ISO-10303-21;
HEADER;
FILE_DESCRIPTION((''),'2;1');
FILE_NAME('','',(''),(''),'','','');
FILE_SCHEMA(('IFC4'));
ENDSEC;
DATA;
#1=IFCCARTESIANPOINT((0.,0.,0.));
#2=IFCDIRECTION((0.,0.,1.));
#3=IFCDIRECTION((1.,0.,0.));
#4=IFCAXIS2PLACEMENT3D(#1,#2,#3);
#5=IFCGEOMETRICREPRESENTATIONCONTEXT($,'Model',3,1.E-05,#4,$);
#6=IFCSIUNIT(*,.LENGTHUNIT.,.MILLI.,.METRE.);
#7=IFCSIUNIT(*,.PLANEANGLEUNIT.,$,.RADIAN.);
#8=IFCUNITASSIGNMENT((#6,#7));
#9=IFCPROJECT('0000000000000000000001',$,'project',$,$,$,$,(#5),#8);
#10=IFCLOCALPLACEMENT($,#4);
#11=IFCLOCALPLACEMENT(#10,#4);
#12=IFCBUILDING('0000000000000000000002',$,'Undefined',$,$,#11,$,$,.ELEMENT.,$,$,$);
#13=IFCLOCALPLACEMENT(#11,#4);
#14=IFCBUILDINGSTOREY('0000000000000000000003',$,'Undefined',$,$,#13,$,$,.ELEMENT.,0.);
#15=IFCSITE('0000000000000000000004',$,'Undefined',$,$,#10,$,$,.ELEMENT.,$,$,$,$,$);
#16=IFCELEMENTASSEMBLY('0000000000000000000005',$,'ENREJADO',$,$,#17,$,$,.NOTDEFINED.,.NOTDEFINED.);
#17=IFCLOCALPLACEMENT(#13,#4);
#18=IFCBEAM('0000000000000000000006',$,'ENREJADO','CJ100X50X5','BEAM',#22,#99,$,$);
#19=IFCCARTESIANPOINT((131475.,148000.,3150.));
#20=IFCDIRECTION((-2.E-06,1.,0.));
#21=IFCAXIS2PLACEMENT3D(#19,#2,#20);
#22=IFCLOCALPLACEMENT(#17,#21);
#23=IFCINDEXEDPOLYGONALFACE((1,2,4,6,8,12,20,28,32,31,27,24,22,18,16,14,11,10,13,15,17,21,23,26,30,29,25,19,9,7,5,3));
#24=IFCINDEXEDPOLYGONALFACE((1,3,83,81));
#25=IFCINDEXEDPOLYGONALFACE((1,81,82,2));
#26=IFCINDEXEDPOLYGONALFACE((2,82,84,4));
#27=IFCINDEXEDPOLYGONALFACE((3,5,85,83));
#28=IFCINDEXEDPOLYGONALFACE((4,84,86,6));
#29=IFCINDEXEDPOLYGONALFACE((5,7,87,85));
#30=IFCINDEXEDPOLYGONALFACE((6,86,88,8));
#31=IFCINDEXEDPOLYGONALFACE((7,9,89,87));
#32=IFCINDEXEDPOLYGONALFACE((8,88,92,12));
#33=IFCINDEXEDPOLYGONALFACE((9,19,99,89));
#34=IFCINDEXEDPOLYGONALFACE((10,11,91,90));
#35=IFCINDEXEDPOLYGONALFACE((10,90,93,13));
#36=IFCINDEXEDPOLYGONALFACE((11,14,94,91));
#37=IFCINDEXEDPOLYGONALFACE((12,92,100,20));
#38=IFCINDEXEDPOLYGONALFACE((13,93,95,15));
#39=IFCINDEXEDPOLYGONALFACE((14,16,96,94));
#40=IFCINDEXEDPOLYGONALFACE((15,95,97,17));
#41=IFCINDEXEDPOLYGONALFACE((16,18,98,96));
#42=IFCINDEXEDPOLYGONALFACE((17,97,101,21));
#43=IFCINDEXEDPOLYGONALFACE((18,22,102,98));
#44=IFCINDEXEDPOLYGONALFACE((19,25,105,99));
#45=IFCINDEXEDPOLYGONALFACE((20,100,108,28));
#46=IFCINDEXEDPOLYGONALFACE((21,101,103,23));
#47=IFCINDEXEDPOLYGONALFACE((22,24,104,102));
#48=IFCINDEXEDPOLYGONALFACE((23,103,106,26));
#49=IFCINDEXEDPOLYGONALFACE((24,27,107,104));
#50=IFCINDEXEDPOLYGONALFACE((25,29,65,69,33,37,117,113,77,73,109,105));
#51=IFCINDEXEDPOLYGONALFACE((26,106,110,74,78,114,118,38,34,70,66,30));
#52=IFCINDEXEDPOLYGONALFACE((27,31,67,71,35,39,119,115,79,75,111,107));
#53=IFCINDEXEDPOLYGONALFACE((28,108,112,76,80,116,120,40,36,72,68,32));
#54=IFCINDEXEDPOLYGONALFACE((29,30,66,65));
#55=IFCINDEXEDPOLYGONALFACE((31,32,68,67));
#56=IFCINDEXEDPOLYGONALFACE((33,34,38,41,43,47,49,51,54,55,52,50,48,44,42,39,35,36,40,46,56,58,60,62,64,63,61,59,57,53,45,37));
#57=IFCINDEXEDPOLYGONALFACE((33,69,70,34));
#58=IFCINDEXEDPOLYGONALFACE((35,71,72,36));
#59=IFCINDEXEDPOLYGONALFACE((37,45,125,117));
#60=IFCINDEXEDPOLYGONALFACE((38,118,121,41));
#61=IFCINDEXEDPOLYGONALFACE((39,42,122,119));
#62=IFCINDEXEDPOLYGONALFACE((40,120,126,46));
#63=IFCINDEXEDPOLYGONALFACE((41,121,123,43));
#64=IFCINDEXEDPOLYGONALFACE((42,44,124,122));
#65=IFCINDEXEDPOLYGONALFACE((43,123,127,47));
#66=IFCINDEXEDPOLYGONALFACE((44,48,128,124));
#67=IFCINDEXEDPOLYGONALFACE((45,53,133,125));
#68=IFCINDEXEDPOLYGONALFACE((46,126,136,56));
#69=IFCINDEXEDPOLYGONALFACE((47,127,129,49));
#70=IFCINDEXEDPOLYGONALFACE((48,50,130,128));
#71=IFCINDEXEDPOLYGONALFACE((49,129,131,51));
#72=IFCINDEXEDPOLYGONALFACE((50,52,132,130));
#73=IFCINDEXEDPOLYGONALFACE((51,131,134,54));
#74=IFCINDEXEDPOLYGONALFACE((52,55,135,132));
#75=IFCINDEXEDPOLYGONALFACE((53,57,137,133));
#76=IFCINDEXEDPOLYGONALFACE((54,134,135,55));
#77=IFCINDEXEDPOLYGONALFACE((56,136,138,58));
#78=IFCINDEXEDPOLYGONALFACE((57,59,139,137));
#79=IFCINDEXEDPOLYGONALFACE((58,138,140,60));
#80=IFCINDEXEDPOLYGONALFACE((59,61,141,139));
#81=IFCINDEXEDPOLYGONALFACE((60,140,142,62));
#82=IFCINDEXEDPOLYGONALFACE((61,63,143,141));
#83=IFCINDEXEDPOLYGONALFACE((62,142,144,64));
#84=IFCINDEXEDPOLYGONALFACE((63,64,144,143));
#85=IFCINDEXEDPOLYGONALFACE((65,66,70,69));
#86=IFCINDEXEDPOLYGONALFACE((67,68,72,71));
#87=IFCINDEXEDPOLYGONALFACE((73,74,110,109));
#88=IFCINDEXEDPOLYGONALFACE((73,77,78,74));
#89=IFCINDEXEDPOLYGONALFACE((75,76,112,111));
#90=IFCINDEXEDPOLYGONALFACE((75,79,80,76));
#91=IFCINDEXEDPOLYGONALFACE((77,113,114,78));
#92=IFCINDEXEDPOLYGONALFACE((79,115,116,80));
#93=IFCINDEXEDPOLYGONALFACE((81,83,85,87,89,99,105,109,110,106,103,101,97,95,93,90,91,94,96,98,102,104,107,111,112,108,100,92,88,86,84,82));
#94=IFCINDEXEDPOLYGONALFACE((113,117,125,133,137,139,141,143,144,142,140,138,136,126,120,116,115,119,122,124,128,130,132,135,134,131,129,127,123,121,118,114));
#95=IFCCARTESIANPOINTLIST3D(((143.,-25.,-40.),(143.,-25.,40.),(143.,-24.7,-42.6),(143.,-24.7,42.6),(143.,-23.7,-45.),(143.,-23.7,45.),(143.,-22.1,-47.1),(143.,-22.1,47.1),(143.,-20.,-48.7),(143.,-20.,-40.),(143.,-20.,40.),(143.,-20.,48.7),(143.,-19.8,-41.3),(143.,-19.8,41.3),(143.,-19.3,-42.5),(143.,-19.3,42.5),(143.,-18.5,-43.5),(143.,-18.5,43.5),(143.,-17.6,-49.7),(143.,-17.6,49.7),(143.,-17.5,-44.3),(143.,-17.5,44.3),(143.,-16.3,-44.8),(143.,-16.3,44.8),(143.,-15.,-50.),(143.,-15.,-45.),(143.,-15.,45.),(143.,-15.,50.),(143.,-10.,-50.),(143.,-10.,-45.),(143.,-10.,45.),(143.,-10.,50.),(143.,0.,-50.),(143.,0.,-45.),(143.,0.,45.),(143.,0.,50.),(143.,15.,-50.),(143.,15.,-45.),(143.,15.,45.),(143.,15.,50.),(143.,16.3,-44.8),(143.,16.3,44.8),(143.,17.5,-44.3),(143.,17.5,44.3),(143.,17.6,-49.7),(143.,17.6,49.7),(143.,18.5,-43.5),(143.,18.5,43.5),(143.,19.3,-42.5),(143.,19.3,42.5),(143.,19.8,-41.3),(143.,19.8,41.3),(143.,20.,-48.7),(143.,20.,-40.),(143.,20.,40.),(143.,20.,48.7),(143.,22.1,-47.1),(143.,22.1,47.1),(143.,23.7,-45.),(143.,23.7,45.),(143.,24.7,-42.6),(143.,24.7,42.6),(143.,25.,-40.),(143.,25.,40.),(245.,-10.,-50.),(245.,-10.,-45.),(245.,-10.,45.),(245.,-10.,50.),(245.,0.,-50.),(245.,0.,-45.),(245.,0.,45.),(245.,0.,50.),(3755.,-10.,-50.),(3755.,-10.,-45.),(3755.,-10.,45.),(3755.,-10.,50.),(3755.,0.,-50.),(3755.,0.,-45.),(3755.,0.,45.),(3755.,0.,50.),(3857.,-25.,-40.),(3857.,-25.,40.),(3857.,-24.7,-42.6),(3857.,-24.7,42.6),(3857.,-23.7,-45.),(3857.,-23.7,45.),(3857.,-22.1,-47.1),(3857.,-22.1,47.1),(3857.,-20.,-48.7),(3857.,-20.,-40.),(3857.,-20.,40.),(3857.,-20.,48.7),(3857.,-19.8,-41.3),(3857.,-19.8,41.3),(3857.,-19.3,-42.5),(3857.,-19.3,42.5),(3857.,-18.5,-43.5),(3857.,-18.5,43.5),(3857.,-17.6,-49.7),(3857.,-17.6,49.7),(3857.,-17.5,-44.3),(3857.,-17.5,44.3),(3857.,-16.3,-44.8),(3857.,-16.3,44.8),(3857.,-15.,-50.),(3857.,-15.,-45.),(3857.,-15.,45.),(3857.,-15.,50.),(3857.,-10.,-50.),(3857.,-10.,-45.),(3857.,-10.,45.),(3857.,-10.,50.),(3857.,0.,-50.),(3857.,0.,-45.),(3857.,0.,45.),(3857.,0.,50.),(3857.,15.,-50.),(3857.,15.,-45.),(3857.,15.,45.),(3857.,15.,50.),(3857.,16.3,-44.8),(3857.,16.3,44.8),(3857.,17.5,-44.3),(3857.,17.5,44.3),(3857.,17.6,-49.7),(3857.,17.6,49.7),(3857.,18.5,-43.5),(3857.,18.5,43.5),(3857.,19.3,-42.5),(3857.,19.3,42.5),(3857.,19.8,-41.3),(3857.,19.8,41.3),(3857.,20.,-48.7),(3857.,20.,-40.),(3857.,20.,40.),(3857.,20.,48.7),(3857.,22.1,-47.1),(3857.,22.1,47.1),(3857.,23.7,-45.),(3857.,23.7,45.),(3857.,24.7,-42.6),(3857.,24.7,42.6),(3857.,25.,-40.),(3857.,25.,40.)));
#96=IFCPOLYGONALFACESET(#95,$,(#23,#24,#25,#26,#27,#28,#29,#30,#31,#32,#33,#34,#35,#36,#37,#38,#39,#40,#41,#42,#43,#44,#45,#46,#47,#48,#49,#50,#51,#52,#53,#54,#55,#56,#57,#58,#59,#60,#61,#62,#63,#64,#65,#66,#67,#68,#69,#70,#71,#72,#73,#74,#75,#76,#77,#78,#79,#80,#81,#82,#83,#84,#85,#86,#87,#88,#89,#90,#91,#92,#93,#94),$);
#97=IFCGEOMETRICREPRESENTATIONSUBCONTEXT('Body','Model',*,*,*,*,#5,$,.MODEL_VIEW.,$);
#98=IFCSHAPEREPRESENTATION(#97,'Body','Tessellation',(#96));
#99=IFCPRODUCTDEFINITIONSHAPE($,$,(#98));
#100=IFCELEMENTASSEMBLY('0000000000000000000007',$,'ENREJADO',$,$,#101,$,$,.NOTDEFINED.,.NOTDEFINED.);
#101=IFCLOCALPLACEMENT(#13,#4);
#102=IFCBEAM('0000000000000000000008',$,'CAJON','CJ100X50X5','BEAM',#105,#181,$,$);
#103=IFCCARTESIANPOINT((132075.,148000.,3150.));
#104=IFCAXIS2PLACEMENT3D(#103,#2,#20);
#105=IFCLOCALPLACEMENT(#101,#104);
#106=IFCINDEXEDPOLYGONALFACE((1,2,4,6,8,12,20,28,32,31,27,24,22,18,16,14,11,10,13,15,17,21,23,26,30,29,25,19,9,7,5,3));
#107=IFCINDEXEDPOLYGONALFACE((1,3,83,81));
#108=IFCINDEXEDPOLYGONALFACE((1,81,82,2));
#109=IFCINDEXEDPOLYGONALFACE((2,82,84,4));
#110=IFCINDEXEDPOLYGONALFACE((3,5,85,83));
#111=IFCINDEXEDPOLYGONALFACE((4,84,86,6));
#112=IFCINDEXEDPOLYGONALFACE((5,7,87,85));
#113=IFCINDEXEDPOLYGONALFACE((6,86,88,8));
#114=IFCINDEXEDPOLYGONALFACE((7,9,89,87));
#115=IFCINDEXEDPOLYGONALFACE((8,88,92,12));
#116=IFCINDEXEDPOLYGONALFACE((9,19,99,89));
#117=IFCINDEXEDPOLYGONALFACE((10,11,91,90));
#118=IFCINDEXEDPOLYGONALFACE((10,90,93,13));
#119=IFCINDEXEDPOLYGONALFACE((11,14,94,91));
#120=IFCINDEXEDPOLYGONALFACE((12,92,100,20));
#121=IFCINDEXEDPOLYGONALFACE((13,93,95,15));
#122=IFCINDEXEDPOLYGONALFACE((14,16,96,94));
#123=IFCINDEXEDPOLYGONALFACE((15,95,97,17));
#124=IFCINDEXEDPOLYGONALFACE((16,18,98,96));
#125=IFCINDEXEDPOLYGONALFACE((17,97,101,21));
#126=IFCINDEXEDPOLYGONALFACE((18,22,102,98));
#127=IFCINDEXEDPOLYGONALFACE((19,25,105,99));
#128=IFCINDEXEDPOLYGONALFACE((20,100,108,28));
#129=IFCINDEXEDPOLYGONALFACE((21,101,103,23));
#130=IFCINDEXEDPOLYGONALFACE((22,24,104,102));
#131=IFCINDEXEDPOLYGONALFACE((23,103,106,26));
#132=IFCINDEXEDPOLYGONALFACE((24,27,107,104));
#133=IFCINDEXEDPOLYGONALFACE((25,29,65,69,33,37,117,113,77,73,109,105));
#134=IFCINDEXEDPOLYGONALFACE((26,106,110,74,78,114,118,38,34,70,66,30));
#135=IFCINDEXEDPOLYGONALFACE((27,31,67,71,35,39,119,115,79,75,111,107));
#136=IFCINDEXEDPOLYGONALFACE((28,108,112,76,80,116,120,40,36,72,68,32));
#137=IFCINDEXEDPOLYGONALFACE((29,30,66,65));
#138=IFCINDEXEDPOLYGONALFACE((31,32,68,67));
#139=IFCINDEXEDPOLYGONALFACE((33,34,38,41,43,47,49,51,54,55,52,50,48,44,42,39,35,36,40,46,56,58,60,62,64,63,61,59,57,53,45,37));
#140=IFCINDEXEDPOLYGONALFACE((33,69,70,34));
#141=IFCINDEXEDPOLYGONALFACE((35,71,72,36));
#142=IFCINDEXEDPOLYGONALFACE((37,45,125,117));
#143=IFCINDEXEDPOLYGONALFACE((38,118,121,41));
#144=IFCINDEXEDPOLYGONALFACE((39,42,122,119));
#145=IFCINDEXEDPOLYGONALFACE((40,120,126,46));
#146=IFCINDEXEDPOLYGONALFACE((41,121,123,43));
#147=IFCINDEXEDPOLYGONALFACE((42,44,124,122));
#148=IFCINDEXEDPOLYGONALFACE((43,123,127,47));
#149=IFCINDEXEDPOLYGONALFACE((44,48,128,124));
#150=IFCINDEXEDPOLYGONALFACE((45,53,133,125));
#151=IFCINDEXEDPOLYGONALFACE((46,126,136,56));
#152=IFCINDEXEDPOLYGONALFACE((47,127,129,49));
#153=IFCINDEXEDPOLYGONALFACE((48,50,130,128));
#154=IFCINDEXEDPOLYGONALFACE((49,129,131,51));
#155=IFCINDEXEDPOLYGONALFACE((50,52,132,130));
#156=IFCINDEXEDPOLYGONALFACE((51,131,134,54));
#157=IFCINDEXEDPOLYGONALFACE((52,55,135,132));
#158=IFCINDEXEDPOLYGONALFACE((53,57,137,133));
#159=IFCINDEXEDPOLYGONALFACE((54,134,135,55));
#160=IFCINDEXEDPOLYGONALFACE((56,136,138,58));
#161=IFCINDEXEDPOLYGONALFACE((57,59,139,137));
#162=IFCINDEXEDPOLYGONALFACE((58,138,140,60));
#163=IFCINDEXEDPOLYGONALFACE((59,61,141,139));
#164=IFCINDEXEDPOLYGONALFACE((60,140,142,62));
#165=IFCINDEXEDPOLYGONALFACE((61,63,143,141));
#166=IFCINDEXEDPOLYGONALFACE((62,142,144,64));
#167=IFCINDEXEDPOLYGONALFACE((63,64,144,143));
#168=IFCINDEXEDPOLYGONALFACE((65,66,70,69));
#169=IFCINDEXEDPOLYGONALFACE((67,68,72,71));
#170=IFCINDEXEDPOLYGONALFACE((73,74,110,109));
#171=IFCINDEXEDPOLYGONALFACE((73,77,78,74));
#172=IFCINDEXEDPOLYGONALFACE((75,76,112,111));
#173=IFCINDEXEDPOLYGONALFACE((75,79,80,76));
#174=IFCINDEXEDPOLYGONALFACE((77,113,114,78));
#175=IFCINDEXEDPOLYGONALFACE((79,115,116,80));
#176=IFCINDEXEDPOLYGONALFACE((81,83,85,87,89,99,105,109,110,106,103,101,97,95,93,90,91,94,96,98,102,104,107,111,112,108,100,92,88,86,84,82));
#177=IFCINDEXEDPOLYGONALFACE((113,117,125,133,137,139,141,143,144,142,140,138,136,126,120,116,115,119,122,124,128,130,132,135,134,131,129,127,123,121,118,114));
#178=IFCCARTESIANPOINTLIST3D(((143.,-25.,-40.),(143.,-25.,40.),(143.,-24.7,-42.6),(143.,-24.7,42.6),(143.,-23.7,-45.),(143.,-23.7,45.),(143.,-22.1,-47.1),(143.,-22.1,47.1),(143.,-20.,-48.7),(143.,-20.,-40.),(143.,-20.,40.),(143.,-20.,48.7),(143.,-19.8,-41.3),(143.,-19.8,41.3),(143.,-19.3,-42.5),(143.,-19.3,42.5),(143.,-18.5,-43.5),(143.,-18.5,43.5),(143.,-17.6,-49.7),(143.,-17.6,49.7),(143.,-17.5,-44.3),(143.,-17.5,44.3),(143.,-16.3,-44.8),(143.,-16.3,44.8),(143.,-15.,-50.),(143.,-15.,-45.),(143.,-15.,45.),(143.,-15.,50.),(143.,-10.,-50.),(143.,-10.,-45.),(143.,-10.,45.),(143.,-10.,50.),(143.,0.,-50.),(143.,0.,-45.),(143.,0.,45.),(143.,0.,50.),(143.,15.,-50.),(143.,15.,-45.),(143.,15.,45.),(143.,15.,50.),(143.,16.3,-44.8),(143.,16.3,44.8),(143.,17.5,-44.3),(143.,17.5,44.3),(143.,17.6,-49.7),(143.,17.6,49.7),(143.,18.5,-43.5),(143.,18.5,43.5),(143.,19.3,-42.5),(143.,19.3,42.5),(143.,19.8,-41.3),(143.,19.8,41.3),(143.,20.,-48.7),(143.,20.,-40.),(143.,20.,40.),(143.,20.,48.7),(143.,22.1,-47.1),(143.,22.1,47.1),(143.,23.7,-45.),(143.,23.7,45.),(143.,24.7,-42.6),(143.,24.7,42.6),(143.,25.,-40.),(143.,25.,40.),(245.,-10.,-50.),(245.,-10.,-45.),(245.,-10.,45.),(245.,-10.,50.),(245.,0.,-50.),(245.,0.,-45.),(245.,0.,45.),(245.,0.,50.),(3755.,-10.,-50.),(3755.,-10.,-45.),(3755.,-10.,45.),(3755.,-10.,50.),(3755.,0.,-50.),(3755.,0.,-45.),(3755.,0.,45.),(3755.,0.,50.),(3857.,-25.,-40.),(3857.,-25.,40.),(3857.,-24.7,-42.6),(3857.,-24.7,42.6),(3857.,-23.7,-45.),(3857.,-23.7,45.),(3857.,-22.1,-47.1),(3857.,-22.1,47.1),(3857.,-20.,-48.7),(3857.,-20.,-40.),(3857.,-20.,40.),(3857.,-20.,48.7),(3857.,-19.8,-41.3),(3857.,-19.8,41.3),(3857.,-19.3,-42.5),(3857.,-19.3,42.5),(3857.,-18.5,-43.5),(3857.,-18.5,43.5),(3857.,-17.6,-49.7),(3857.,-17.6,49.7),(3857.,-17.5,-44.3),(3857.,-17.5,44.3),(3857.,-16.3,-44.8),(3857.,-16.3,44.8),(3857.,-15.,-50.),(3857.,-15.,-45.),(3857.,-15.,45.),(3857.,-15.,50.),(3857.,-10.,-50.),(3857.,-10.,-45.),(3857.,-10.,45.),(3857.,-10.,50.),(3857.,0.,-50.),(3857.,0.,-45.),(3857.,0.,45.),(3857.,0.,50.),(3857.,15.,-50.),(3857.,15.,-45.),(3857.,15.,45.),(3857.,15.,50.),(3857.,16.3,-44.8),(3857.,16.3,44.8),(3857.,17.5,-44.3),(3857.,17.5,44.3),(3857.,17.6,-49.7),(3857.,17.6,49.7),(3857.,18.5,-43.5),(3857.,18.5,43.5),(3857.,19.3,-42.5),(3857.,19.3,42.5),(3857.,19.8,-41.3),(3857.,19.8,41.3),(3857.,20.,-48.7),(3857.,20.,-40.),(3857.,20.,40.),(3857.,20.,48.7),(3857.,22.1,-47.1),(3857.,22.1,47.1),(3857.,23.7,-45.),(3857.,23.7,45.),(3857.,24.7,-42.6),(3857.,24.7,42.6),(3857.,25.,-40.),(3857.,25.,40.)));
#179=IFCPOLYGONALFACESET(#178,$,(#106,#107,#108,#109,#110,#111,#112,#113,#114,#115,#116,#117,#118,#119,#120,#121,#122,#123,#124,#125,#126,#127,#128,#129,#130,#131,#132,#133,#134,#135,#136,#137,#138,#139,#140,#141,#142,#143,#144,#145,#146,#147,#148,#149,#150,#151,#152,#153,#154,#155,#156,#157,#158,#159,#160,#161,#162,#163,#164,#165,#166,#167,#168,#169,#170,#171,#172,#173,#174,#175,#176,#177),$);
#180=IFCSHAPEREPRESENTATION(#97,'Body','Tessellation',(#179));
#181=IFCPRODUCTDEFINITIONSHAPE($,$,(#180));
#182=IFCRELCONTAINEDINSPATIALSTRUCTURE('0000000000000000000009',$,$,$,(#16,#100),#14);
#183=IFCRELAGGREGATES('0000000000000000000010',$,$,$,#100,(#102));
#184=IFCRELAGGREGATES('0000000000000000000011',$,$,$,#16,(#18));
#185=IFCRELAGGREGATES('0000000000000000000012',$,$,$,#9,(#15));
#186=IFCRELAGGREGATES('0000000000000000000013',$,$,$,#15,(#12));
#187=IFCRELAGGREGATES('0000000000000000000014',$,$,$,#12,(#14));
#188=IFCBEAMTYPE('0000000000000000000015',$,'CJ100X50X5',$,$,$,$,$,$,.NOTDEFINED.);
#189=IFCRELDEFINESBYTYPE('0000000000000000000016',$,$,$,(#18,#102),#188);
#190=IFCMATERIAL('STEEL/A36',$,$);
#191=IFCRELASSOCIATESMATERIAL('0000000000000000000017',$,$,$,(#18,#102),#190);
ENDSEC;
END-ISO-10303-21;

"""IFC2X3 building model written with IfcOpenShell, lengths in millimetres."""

from ifc_helpers import new_model, si_unit, frame, origin_with_axes, origin_2d_with_axis, place, context, subcontext, project, spatial, rectangle, hollow_rectangle, extrude, boolean, halfspace, material, type_object, element, aggregate, save


model = new_model("IFC2X3")

# Units and contexts
model_context = context("Model", 3, precision=1e-05, world=origin_with_axes())
body_context = subcontext(model_context, "Body", "Model", "MODEL_VIEW")
ifc_project = project(units=[si_unit("LENGTHUNIT", "METRE", prefix="MILLI"), si_unit("PLANEANGLEUNIT", "RADIAN")], contexts=[model_context])

# Site, building, storey
site_placement = place(None, origin_with_axes())
site = spatial("IfcSite", under=ifc_project, at=site_placement, Name="Undefined", CompositionType="ELEMENT")
building_placement = place(site_placement, origin_with_axes())
building = spatial("IfcBuilding", under=site, at=building_placement, Name="Undefined", CompositionType="ELEMENT")
storey_placement = place(building_placement, origin_with_axes())
storey = spatial("IfcBuildingStorey", under=building, at=storey_placement, Name="Undefined", CompositionType="ELEMENT", Elevation=0.0)

# Shared definitions
ifc_material_1 = material(Name="STEEL/A36")

# Element assembly
assembly_1_placement = place(storey_placement, origin_with_axes())
assembly_1 = element("IfcElementAssembly", 1, at=assembly_1_placement, inside=storey, Name="ENREJADO", AssemblyPlace="NOTDEFINED", PredefinedType="NOTDEFINED")
beam_type_1 = type_object("IfcBeamType", Name="CJ100X50X5", PredefinedType="NOTDEFINED")

# Beam
beam_1_placement = place(assembly_1_placement, frame((131475.0, 148000.0, 3150.0), z_axis=(0.0, 0.0, 1.0), x_axis=(-0.000002, 1.0, 0.0)))
beam_1 = element("IfcBeam", 2, at=beam_1_placement, type_object=beam_type_1, material=ifc_material_1, Name="ENREJADO", Description="CJ100X50X5", ObjectType="BEAM", context=body_context, shape_type="CSG", body=[
    boolean("DIFFERENCE", boolean("DIFFERENCE", boolean("DIFFERENCE", boolean("DIFFERENCE", extrude(hollow_rectangle(XDim=50.0, YDim=100.0, WallThickness=5.0, InnerFilletRadius=5.0, OuterFilletRadius=10.0, at=origin_2d_with_axis()), frame((4000.0, 0.0, 0.0), z_axis=(-1.0, 0.0, 0.0), x_axis=(0.0, -1.0, 0.0)), (0.0, 0.0, 1.0), 4000.0), extrude(rectangle(XDim=10.0, YDim=104.0, at=origin_2d_with_axis()), frame((3755.0, -5.0, 0.0), z_axis=(1.0, 0.0, 0.0), x_axis=(0.0, 1.0, 0.0)), (0.0, 0.0, 1.0), 120.0)), extrude(rectangle(XDim=10.0, YDim=104.0, at=origin_2d_with_axis()), frame((245.0, -5.0, 0.0), z_axis=(-1.0, 0.000003, 0.0), x_axis=(0.000002, 1.0, 0.0)), (0.0, 0.0, 1.0), 120.0)), halfspace(frame((3857.0, 200.0, 50.0), z_axis=(-1.0, 0.0, 0.0), x_axis=(0.0, -1.0, 0.0)), True)), halfspace(frame((143.0, 200.0, -50.0), z_axis=(1.0, -0.000003, 0.0), x_axis=(-0.000002, -1.0, 0.0)), True)),
])

# Element assembly, beam
assembly_2_placement = place(storey_placement, origin_with_axes())
assembly_2 = element("IfcElementAssembly", 3, at=assembly_2_placement, inside=storey, Name="ENREJADO", AssemblyPlace="NOTDEFINED", PredefinedType="NOTDEFINED")
beam_2_placement = place(assembly_2_placement, frame((132075.0, 148000.0, 3150.0), z_axis=(0.0, 0.0, 1.0), x_axis=(-0.000002, 1.0, 0.0)))
beam_2 = element("IfcBeam", 4, at=beam_2_placement, type_object=beam_type_1, material=ifc_material_1, Name="CAJON", Description="CJ100X50X5", ObjectType="BEAM", context=body_context, shape_type="CSG", body=[
    boolean("DIFFERENCE", boolean("DIFFERENCE", boolean("DIFFERENCE", boolean("DIFFERENCE", extrude(hollow_rectangle(XDim=50.0, YDim=100.0, WallThickness=5.0, InnerFilletRadius=5.0, OuterFilletRadius=10.0, at=origin_2d_with_axis()), frame((4000.0, 0.0, 0.0), z_axis=(-1.0, 0.0, 0.0), x_axis=(0.0, -1.0, 0.0)), (0.0, 0.0, 1.0), 4000.0), extrude(rectangle(XDim=10.0, YDim=104.0, at=origin_2d_with_axis()), frame((3755.0, -5.0, 0.0), z_axis=(1.0, 0.0, 0.0), x_axis=(0.0, 1.0, 0.0)), (0.0, 0.0, 1.0), 120.0)), extrude(rectangle(XDim=10.0, YDim=104.0, at=origin_2d_with_axis()), frame((245.0, -5.0, 0.0), z_axis=(-1.0, 0.000003, 0.0), x_axis=(0.000002, 1.0, 0.0)), (0.0, 0.0, 1.0), 120.0)), halfspace(frame((3857.0, 200.0, 50.0), z_axis=(-1.0, 0.0, 0.0), x_axis=(0.0, -1.0, 0.0)), True)), halfspace(frame((143.0, 200.0, -50.0), z_axis=(1.0, -0.000003, 0.0), x_axis=(-0.000002, -1.0, 0.0)), True)),
])

aggregate(assembly_2, [beam_2])
aggregate(assembly_1, [beam_1])

save(model, "model.ifc")
